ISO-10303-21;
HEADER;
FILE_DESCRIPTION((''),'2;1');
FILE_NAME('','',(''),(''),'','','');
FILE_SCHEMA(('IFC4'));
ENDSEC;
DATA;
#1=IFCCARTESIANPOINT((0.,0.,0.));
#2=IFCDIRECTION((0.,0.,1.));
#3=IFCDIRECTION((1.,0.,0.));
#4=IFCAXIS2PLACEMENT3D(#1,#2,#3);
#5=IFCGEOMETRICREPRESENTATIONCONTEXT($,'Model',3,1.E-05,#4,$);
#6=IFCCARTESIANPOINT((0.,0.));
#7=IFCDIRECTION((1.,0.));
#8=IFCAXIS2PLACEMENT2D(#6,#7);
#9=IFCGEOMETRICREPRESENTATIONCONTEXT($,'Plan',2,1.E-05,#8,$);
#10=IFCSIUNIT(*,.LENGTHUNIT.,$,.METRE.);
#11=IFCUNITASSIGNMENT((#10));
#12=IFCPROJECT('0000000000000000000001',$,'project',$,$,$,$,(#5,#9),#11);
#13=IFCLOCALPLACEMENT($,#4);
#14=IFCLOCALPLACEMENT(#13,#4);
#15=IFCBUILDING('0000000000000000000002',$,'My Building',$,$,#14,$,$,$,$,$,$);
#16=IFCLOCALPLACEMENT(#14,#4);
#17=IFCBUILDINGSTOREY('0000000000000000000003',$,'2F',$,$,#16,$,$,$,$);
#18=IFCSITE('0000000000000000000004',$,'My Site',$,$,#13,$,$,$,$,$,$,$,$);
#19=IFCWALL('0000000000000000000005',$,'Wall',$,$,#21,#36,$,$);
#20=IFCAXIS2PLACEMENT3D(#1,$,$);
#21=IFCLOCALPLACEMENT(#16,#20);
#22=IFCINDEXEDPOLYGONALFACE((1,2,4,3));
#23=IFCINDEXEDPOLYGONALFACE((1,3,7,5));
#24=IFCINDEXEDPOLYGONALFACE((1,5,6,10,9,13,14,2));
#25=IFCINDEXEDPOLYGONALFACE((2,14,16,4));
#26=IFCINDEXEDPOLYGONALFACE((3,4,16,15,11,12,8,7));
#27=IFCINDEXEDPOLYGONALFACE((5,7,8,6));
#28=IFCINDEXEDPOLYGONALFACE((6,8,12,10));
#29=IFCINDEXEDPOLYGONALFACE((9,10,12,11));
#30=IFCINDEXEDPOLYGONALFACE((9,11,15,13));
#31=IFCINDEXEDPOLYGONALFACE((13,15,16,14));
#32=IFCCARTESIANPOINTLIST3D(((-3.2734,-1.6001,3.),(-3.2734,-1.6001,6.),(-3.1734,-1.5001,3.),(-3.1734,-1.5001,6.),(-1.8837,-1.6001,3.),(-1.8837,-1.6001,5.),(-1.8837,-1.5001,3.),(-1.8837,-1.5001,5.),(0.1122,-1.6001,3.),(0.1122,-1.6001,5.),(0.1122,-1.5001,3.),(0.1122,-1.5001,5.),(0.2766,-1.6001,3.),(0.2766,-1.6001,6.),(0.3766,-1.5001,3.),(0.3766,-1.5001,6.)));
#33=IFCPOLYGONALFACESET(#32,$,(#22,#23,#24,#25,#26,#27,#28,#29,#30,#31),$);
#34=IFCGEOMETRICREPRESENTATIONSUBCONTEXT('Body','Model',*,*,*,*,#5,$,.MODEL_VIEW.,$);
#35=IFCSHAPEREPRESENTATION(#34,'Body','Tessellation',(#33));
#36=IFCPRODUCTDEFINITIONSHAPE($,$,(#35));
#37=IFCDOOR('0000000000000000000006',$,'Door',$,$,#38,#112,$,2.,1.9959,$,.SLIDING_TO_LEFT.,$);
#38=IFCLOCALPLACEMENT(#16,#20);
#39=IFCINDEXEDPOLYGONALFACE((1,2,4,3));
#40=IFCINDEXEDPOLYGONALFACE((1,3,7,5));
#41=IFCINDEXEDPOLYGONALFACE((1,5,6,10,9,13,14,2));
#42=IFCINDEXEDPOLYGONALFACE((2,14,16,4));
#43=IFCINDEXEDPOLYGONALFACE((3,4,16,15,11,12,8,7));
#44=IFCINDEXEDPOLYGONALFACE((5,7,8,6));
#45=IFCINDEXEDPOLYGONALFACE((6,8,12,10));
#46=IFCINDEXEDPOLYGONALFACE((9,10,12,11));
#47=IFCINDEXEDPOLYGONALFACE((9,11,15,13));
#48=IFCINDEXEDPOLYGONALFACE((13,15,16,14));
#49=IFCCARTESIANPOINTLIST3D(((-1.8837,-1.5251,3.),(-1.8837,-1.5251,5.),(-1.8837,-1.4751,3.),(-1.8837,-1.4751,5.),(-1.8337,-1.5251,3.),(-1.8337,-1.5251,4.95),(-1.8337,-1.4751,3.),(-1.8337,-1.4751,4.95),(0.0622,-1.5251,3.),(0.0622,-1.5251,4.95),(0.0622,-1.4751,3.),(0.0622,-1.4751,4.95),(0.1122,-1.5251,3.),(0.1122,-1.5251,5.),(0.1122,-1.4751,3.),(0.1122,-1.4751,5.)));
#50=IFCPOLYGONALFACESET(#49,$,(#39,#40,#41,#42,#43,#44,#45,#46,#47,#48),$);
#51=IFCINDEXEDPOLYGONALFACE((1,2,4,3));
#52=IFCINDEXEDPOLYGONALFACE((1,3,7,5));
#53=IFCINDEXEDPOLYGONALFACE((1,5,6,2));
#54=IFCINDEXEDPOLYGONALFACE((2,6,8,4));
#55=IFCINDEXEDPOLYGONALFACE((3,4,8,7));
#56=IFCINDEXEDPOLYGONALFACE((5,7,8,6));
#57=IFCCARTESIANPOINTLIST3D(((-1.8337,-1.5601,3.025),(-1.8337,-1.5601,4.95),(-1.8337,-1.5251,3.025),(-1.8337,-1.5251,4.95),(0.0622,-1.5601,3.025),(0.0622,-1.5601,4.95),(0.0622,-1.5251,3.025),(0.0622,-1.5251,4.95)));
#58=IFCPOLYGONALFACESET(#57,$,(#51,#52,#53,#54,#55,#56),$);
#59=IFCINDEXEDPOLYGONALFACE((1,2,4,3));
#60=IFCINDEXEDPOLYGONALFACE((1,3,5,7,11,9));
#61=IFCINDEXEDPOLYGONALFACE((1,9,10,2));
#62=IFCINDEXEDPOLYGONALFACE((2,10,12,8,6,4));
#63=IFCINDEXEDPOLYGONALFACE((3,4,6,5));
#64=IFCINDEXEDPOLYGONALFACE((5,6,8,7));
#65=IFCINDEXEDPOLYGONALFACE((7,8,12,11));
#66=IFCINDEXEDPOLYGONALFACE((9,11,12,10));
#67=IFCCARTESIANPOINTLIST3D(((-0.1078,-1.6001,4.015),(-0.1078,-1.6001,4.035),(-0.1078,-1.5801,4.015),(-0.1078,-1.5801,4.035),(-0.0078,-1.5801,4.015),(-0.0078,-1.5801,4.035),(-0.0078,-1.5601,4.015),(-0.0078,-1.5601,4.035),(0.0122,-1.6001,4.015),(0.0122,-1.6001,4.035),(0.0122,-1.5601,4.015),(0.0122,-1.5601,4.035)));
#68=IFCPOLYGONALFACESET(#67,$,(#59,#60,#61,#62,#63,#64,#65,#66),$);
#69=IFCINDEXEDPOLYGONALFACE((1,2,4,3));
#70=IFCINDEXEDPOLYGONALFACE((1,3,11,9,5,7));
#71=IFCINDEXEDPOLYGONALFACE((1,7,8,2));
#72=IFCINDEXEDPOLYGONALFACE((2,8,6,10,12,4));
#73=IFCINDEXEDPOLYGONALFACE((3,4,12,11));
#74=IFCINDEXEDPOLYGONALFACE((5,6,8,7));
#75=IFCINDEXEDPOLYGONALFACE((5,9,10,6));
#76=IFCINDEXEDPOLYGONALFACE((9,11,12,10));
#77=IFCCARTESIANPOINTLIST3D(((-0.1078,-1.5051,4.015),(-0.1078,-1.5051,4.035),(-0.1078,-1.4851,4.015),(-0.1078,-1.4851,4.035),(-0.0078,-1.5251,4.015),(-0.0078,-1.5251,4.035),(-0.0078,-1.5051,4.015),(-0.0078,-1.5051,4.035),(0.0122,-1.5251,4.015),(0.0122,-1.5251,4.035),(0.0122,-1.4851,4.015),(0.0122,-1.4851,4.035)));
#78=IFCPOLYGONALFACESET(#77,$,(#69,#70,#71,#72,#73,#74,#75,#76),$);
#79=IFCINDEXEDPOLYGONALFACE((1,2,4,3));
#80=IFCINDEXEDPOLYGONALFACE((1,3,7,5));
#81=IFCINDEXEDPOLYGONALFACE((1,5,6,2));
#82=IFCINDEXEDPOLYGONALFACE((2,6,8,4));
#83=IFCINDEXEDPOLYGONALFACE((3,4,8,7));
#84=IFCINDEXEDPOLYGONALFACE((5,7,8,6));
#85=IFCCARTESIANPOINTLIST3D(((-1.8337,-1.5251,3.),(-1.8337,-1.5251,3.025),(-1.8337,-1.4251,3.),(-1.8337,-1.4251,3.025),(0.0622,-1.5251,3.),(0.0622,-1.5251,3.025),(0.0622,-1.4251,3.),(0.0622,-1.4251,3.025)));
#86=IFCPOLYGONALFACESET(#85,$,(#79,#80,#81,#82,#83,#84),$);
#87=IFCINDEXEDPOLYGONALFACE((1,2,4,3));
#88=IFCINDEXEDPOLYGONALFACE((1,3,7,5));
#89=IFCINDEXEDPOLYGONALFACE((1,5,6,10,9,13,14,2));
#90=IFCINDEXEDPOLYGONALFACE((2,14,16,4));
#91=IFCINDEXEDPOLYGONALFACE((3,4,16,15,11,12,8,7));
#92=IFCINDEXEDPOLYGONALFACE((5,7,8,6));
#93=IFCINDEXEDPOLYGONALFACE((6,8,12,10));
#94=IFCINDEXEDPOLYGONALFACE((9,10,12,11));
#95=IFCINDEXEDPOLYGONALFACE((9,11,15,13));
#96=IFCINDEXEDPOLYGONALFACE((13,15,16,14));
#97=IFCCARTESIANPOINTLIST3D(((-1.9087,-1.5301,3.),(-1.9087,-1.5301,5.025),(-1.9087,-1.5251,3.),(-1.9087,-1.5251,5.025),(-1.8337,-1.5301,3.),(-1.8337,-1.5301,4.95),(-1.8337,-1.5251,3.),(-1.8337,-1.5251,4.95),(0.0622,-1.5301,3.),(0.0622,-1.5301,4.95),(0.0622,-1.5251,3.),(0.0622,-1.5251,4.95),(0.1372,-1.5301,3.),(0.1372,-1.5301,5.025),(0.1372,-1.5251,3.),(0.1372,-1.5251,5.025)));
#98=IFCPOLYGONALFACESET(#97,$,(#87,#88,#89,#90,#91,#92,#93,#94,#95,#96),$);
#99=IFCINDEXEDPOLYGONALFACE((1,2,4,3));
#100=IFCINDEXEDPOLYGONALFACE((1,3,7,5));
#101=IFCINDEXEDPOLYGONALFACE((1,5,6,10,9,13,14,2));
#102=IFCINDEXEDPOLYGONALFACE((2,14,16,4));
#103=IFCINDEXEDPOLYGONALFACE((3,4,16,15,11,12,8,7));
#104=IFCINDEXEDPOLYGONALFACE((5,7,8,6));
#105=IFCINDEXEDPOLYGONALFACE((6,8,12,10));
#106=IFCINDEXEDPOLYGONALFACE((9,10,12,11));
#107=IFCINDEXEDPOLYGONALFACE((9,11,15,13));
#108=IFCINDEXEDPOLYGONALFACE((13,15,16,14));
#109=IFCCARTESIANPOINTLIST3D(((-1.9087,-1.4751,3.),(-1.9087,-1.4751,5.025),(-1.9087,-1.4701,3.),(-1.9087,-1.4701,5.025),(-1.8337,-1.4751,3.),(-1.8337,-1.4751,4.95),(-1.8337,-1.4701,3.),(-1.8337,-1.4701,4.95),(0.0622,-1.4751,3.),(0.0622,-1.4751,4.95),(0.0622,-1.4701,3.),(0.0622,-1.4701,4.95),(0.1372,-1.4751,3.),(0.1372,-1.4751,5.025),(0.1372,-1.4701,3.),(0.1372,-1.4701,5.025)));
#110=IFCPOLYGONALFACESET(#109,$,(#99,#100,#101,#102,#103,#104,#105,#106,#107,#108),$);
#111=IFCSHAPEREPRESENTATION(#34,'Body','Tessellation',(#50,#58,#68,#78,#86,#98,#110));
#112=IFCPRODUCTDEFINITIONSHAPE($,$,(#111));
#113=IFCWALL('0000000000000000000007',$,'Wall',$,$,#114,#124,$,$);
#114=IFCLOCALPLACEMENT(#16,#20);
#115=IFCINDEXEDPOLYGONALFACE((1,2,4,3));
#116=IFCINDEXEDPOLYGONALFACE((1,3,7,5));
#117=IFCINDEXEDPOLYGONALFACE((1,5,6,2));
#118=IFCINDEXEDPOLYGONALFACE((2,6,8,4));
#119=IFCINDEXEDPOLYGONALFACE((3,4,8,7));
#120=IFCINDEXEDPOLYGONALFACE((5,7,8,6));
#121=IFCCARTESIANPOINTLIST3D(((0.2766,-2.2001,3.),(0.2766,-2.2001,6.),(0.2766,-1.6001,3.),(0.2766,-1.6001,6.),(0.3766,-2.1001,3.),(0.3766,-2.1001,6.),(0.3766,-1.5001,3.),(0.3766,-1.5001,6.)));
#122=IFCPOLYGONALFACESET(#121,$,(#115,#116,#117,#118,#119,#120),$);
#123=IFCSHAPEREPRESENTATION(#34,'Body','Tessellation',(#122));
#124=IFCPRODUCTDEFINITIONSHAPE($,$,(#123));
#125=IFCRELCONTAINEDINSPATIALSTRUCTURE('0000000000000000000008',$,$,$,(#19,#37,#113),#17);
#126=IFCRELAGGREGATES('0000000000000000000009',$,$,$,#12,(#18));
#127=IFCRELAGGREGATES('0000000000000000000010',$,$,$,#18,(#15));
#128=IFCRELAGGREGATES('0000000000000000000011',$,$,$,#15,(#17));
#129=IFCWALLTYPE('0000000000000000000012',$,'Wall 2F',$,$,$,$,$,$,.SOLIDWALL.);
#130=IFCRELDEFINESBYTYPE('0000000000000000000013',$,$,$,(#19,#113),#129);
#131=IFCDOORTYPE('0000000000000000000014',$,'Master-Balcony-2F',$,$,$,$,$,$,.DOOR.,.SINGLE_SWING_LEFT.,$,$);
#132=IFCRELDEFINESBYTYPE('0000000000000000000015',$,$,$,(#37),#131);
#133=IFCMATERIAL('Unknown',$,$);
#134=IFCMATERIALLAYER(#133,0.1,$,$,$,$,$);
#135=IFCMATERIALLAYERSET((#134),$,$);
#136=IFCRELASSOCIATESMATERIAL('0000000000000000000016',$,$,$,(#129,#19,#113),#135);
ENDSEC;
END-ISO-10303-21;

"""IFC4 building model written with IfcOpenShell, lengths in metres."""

from ifc_helpers import new_model, entity, si_unit, frame, origin_with_axes, origin_2d_with_axis, place, context, subcontext, project, spatial, line, indexed_curve, outline, extrude, shape, source, transform, mapped, material, layer, layer_set, layer_usage, type_object, type_shapes, element, fill, save


model = new_model("IFC4")

# Units and contexts
model_context = context("Model", 3, precision=1e-05, world=origin_with_axes())
plan_context = context("Plan", 2, precision=1e-05, world=origin_2d_with_axis())
body_context_1 = subcontext(model_context, "Body", "Model", "MODEL_VIEW")
body_context_2 = subcontext(plan_context, "Body", "Plan", "PLAN_VIEW")
ifc_project = project(units=[si_unit("LENGTHUNIT", "METRE")], contexts=[model_context, plan_context])

# Site, building, storey
site_placement = place(None, origin_with_axes())
site = spatial("IfcSite", under=ifc_project, at=site_placement, Name="My Site")
building_placement = place(site_placement, origin_with_axes())
building = spatial("IfcBuilding", under=site, at=building_placement, Name="My Building")
storey_placement = place(building_placement, origin_with_axes())
storey = spatial("IfcBuildingStorey", under=building, at=storey_placement, Name="2F")

# Shared definitions
ifc_material = material(Name="Unknown")

# Wall, opening, door
ifc_layer = layer(ifc_material, 0.1)
ifc_layer_set = layer_set([ifc_layer])
ifc_layer_usage_1 = layer_usage(ifc_layer_set, "AXIS2", "POSITIVE", 0.0)
wall_type = type_object("IfcWallType", Name="Wall 2F", PredefinedType="SOLIDWALL", material=ifc_layer_set)
wall_1_placement = place(storey_placement, frame((-3.2734, -1.6001, 3.0), z_axis=(0.0, 0.0, 1.0), x_axis=(1.0, 0.0, 0.0)))
wall_1 = element("IfcWall", 1, at=wall_1_placement, inside=storey, type_object=wall_type, material=ifc_layer_usage_1, Name="Wall", context=body_context_1, shape_type="SweptSolid", body=[
    extrude(outline(indexed_curve([(0.0, 0.0), (0.1, 0.1), (3.65, 0.1), (3.55, 0.0)], segments=[line(1, 2, 3, 4, 1)])), origin_with_axes(), (0.0, 0.0, 1.0), 3.0),
])
shared_shape_1 = source(origin_with_axes(), body_context_1, "Body", "SweptSolid", [
    extrude(outline(indexed_curve([(0.0, 0.0), (1.9959, 0.0), (1.9959, 2.0), (0.0, 2.0)], segments=[line(1, 2, 3, 4, 1)])), frame((0.0, -0.6, 0.0), z_axis=(0.0, -1.0, 0.0), x_axis=(1.0, 0.0, 0.0)), (0.0, 0.0, -1.0), 1.2),
])
opening_1_placement = place(wall_1_placement, frame((1.3897, 0.075, 0.0), z_axis=(0.0, 0.0, 1.0), x_axis=(1.0, 0.0, 0.0)))
opening_1 = element("IfcOpeningElement", 2, at=opening_1_placement, cuts=wall_1, PredefinedType="OPENING", context=body_context_1, shape_type="MappedRepresentation", body=[
    mapped(shared_shape_1, transform((0.0, 0.0, 0.0), x_axis=(1.0, 0.0, 0.0), y_axis=(0.0, 1.0, 0.0), z_axis=(0.0, 0.0, 1.0), scale=1.0)),
])
door_type_1 = type_object("IfcDoorType", Name="Master-Balcony-2F", OperationType="SINGLE_SWING_LEFT", PredefinedType="DOOR")
shared_shape_2 = source(origin_with_axes(), body_context_1, "Body", "SweptSolid", [
    extrude(outline(indexed_curve([(0.0, 0.0), (0.0, 2.0), (1.9959, 2.0), (1.9959, 0.0), (1.9459, 0.0), (1.9459, 1.95), (0.05, 1.95), (0.05, 0.0)], segments=[line(1, 2, 3, 4, 5, 6, 7, 8, 1)])), frame((0.0, 0.0, 0.0), z_axis=(0.0, -1.0, 0.0), x_axis=(1.0, 0.0, 0.0)), (0.0, 0.0, -1.0), 0.05),
    extrude(outline(indexed_curve([(0.0, 0.0), (1.8959, 0.0), (1.8959, 0.035), (0.0, 0.035)], segments=[line(1, 2, 3, 4, 1)])), frame((0.05, -0.035, 0.025), z_axis=(0.0, 0.0, 1.0), x_axis=(1.0, 0.0, 0.0)), (0.0, 0.0, 1.0), 1.925),
    extrude(outline(indexed_curve([(0.0, 0.0), (0.0, -0.04), (-0.12, -0.04), (-0.12, -0.02), (-0.02, -0.02), (-0.02, 0.0)], segments=[line(1, 2, 3, 4, 5, 6, 1)])), frame((1.8959, -0.035, 1.015), z_axis=(0.0, 0.0, 1.0), x_axis=(1.0, 0.0, 0.0)), (0.0, 0.0, 1.0), 0.02),
    extrude(outline(indexed_curve([(0.0, 0.0), (0.0, 0.04), (-0.12, 0.04), (-0.12, 0.02), (-0.02, 0.02), (-0.02, 0.0)], segments=[line(1, 2, 3, 4, 5, 6, 1)])), frame((1.8959, 0.0, 1.015), z_axis=(0.0, 0.0, 1.0), x_axis=(1.0, 0.0, 0.0)), (0.0, 0.0, 1.0), 0.02),
    extrude(outline(indexed_curve([(0.0, 0.0), (1.8959, 0.0), (1.8959, 0.1), (0.0, 0.1)], segments=[line(1, 2, 3, 4, 1)])), frame((0.05, 0.0, 0.0), z_axis=(0.0, 0.0, 1.0), x_axis=(1.0, 0.0, 0.0)), (0.0, 0.0, 1.0), 0.025),
    extrude(outline(indexed_curve([(0.0, 0.0), (0.0, 2.025), (2.0459, 2.025), (2.0459, 0.0), (1.9709, 0.0), (1.9709, 1.95), (0.075, 1.95), (0.075, 0.0)], segments=[line(1, 2, 3, 4, 5, 6, 7, 8, 1)])), frame((-0.025, -0.005, 0.0), z_axis=(0.0, -1.0, 0.0), x_axis=(1.0, 0.0, 0.0)), (0.0, 0.0, -1.0), 0.005),
    extrude(outline(indexed_curve([(0.0, 0.0), (0.0, 2.025), (2.0459, 2.025), (2.0459, 0.0), (1.9709, 0.0), (1.9709, 1.95), (0.075, 1.95), (0.075, 0.0)], segments=[line(1, 2, 3, 4, 5, 6, 7, 8, 1)])), frame((-0.025, 0.05, 0.0), z_axis=(0.0, -1.0, 0.0), x_axis=(1.0, 0.0, 0.0)), (0.0, 0.0, -1.0), 0.005),
])
shared_shape_3 = source(origin_with_axes(), body_context_2, "Body", "Curve2D", [
    entity("IfcIndexedPolyCurve", entity("IfcCartesianPointList2D", [[0.0, 0.0], [0.05, 0.0], [0.05, 0.05], [0.0, 0.05]]), [entity("IfcLineIndex", [1, 2, 3, 4, 1])]),
    entity("IfcIndexedPolyCurve", entity("IfcCartesianPointList2D", [[1.9959, 0.0], [1.9459, 0.0], [1.9459, 0.05], [1.9959, 0.05]]), [entity("IfcLineIndex", [1, 2, 3, 4, 1])]),
    entity("IfcIndexedPolyCurve", entity("IfcCartesianPointList2D", [[-0.8979, -0.035], [0.9979, -0.035], [0.9979, 0.0], [-0.8979, 0.0]]), [entity("IfcLineIndex", [1, 2, 3, 4, 1])]),
])
type_shapes(door_type_1, [shared_shape_2, shared_shape_3])
door_1_placement = place(opening_1_placement, frame((0.0, 0.0, 0.0), z_axis=(0.0, 0.0, 1.0), x_axis=(1.0, 0.0, 0.0)))
door_1 = element("IfcDoor", 3, at=door_1_placement, inside=storey, type_object=door_type_1, Name="Door", OperationType="SLIDING_TO_LEFT", OverallHeight=2.0, OverallWidth=1.9959, shapes=[
    shape(body_context_1, "Body", "MappedRepresentation", [mapped(shared_shape_2, transform((0.0, 0.0, 0.0), x_axis=(1.0, 0.0, 0.0), y_axis=(0.0, 1.0, 0.0), z_axis=(0.0, 0.0, 1.0), scale=1.0))]),
    shape(body_context_2, "Body", "MappedRepresentation", [mapped(shared_shape_3, transform((0.0, 0.0, 0.0), x_axis=(1.0, 0.0, 0.0), y_axis=(0.0, 1.0, 0.0), z_axis=(0.0, 0.0, 1.0), scale=1.0))]),
])
fill(opening_1, door_1)

# Wall
ifc_layer_usage_2 = layer_usage(ifc_layer_set, "AXIS2", "POSITIVE", 0.0)
wall_2_placement = place(storey_placement, frame((0.2766, -1.6001, 3.0), z_axis=(0.0, 0.0, 1.0), x_axis=(0.0, -1.0, 0.0)))
element("IfcWall", 4, at=wall_2_placement, inside=storey, type_object=wall_type, material=ifc_layer_usage_2, Name="Wall", context=body_context_1, shape_type="SweptSolid", body=[
    extrude(outline(indexed_curve([(0.0, 0.0), (-0.1, 0.1), (0.5, 0.1), (0.6, 0.0)], segments=[line(1, 2, 3, 4, 1)])), origin_with_axes(), (0.0, 0.0, 1.0), 3.0),
])

save(model, "model.ifc")
